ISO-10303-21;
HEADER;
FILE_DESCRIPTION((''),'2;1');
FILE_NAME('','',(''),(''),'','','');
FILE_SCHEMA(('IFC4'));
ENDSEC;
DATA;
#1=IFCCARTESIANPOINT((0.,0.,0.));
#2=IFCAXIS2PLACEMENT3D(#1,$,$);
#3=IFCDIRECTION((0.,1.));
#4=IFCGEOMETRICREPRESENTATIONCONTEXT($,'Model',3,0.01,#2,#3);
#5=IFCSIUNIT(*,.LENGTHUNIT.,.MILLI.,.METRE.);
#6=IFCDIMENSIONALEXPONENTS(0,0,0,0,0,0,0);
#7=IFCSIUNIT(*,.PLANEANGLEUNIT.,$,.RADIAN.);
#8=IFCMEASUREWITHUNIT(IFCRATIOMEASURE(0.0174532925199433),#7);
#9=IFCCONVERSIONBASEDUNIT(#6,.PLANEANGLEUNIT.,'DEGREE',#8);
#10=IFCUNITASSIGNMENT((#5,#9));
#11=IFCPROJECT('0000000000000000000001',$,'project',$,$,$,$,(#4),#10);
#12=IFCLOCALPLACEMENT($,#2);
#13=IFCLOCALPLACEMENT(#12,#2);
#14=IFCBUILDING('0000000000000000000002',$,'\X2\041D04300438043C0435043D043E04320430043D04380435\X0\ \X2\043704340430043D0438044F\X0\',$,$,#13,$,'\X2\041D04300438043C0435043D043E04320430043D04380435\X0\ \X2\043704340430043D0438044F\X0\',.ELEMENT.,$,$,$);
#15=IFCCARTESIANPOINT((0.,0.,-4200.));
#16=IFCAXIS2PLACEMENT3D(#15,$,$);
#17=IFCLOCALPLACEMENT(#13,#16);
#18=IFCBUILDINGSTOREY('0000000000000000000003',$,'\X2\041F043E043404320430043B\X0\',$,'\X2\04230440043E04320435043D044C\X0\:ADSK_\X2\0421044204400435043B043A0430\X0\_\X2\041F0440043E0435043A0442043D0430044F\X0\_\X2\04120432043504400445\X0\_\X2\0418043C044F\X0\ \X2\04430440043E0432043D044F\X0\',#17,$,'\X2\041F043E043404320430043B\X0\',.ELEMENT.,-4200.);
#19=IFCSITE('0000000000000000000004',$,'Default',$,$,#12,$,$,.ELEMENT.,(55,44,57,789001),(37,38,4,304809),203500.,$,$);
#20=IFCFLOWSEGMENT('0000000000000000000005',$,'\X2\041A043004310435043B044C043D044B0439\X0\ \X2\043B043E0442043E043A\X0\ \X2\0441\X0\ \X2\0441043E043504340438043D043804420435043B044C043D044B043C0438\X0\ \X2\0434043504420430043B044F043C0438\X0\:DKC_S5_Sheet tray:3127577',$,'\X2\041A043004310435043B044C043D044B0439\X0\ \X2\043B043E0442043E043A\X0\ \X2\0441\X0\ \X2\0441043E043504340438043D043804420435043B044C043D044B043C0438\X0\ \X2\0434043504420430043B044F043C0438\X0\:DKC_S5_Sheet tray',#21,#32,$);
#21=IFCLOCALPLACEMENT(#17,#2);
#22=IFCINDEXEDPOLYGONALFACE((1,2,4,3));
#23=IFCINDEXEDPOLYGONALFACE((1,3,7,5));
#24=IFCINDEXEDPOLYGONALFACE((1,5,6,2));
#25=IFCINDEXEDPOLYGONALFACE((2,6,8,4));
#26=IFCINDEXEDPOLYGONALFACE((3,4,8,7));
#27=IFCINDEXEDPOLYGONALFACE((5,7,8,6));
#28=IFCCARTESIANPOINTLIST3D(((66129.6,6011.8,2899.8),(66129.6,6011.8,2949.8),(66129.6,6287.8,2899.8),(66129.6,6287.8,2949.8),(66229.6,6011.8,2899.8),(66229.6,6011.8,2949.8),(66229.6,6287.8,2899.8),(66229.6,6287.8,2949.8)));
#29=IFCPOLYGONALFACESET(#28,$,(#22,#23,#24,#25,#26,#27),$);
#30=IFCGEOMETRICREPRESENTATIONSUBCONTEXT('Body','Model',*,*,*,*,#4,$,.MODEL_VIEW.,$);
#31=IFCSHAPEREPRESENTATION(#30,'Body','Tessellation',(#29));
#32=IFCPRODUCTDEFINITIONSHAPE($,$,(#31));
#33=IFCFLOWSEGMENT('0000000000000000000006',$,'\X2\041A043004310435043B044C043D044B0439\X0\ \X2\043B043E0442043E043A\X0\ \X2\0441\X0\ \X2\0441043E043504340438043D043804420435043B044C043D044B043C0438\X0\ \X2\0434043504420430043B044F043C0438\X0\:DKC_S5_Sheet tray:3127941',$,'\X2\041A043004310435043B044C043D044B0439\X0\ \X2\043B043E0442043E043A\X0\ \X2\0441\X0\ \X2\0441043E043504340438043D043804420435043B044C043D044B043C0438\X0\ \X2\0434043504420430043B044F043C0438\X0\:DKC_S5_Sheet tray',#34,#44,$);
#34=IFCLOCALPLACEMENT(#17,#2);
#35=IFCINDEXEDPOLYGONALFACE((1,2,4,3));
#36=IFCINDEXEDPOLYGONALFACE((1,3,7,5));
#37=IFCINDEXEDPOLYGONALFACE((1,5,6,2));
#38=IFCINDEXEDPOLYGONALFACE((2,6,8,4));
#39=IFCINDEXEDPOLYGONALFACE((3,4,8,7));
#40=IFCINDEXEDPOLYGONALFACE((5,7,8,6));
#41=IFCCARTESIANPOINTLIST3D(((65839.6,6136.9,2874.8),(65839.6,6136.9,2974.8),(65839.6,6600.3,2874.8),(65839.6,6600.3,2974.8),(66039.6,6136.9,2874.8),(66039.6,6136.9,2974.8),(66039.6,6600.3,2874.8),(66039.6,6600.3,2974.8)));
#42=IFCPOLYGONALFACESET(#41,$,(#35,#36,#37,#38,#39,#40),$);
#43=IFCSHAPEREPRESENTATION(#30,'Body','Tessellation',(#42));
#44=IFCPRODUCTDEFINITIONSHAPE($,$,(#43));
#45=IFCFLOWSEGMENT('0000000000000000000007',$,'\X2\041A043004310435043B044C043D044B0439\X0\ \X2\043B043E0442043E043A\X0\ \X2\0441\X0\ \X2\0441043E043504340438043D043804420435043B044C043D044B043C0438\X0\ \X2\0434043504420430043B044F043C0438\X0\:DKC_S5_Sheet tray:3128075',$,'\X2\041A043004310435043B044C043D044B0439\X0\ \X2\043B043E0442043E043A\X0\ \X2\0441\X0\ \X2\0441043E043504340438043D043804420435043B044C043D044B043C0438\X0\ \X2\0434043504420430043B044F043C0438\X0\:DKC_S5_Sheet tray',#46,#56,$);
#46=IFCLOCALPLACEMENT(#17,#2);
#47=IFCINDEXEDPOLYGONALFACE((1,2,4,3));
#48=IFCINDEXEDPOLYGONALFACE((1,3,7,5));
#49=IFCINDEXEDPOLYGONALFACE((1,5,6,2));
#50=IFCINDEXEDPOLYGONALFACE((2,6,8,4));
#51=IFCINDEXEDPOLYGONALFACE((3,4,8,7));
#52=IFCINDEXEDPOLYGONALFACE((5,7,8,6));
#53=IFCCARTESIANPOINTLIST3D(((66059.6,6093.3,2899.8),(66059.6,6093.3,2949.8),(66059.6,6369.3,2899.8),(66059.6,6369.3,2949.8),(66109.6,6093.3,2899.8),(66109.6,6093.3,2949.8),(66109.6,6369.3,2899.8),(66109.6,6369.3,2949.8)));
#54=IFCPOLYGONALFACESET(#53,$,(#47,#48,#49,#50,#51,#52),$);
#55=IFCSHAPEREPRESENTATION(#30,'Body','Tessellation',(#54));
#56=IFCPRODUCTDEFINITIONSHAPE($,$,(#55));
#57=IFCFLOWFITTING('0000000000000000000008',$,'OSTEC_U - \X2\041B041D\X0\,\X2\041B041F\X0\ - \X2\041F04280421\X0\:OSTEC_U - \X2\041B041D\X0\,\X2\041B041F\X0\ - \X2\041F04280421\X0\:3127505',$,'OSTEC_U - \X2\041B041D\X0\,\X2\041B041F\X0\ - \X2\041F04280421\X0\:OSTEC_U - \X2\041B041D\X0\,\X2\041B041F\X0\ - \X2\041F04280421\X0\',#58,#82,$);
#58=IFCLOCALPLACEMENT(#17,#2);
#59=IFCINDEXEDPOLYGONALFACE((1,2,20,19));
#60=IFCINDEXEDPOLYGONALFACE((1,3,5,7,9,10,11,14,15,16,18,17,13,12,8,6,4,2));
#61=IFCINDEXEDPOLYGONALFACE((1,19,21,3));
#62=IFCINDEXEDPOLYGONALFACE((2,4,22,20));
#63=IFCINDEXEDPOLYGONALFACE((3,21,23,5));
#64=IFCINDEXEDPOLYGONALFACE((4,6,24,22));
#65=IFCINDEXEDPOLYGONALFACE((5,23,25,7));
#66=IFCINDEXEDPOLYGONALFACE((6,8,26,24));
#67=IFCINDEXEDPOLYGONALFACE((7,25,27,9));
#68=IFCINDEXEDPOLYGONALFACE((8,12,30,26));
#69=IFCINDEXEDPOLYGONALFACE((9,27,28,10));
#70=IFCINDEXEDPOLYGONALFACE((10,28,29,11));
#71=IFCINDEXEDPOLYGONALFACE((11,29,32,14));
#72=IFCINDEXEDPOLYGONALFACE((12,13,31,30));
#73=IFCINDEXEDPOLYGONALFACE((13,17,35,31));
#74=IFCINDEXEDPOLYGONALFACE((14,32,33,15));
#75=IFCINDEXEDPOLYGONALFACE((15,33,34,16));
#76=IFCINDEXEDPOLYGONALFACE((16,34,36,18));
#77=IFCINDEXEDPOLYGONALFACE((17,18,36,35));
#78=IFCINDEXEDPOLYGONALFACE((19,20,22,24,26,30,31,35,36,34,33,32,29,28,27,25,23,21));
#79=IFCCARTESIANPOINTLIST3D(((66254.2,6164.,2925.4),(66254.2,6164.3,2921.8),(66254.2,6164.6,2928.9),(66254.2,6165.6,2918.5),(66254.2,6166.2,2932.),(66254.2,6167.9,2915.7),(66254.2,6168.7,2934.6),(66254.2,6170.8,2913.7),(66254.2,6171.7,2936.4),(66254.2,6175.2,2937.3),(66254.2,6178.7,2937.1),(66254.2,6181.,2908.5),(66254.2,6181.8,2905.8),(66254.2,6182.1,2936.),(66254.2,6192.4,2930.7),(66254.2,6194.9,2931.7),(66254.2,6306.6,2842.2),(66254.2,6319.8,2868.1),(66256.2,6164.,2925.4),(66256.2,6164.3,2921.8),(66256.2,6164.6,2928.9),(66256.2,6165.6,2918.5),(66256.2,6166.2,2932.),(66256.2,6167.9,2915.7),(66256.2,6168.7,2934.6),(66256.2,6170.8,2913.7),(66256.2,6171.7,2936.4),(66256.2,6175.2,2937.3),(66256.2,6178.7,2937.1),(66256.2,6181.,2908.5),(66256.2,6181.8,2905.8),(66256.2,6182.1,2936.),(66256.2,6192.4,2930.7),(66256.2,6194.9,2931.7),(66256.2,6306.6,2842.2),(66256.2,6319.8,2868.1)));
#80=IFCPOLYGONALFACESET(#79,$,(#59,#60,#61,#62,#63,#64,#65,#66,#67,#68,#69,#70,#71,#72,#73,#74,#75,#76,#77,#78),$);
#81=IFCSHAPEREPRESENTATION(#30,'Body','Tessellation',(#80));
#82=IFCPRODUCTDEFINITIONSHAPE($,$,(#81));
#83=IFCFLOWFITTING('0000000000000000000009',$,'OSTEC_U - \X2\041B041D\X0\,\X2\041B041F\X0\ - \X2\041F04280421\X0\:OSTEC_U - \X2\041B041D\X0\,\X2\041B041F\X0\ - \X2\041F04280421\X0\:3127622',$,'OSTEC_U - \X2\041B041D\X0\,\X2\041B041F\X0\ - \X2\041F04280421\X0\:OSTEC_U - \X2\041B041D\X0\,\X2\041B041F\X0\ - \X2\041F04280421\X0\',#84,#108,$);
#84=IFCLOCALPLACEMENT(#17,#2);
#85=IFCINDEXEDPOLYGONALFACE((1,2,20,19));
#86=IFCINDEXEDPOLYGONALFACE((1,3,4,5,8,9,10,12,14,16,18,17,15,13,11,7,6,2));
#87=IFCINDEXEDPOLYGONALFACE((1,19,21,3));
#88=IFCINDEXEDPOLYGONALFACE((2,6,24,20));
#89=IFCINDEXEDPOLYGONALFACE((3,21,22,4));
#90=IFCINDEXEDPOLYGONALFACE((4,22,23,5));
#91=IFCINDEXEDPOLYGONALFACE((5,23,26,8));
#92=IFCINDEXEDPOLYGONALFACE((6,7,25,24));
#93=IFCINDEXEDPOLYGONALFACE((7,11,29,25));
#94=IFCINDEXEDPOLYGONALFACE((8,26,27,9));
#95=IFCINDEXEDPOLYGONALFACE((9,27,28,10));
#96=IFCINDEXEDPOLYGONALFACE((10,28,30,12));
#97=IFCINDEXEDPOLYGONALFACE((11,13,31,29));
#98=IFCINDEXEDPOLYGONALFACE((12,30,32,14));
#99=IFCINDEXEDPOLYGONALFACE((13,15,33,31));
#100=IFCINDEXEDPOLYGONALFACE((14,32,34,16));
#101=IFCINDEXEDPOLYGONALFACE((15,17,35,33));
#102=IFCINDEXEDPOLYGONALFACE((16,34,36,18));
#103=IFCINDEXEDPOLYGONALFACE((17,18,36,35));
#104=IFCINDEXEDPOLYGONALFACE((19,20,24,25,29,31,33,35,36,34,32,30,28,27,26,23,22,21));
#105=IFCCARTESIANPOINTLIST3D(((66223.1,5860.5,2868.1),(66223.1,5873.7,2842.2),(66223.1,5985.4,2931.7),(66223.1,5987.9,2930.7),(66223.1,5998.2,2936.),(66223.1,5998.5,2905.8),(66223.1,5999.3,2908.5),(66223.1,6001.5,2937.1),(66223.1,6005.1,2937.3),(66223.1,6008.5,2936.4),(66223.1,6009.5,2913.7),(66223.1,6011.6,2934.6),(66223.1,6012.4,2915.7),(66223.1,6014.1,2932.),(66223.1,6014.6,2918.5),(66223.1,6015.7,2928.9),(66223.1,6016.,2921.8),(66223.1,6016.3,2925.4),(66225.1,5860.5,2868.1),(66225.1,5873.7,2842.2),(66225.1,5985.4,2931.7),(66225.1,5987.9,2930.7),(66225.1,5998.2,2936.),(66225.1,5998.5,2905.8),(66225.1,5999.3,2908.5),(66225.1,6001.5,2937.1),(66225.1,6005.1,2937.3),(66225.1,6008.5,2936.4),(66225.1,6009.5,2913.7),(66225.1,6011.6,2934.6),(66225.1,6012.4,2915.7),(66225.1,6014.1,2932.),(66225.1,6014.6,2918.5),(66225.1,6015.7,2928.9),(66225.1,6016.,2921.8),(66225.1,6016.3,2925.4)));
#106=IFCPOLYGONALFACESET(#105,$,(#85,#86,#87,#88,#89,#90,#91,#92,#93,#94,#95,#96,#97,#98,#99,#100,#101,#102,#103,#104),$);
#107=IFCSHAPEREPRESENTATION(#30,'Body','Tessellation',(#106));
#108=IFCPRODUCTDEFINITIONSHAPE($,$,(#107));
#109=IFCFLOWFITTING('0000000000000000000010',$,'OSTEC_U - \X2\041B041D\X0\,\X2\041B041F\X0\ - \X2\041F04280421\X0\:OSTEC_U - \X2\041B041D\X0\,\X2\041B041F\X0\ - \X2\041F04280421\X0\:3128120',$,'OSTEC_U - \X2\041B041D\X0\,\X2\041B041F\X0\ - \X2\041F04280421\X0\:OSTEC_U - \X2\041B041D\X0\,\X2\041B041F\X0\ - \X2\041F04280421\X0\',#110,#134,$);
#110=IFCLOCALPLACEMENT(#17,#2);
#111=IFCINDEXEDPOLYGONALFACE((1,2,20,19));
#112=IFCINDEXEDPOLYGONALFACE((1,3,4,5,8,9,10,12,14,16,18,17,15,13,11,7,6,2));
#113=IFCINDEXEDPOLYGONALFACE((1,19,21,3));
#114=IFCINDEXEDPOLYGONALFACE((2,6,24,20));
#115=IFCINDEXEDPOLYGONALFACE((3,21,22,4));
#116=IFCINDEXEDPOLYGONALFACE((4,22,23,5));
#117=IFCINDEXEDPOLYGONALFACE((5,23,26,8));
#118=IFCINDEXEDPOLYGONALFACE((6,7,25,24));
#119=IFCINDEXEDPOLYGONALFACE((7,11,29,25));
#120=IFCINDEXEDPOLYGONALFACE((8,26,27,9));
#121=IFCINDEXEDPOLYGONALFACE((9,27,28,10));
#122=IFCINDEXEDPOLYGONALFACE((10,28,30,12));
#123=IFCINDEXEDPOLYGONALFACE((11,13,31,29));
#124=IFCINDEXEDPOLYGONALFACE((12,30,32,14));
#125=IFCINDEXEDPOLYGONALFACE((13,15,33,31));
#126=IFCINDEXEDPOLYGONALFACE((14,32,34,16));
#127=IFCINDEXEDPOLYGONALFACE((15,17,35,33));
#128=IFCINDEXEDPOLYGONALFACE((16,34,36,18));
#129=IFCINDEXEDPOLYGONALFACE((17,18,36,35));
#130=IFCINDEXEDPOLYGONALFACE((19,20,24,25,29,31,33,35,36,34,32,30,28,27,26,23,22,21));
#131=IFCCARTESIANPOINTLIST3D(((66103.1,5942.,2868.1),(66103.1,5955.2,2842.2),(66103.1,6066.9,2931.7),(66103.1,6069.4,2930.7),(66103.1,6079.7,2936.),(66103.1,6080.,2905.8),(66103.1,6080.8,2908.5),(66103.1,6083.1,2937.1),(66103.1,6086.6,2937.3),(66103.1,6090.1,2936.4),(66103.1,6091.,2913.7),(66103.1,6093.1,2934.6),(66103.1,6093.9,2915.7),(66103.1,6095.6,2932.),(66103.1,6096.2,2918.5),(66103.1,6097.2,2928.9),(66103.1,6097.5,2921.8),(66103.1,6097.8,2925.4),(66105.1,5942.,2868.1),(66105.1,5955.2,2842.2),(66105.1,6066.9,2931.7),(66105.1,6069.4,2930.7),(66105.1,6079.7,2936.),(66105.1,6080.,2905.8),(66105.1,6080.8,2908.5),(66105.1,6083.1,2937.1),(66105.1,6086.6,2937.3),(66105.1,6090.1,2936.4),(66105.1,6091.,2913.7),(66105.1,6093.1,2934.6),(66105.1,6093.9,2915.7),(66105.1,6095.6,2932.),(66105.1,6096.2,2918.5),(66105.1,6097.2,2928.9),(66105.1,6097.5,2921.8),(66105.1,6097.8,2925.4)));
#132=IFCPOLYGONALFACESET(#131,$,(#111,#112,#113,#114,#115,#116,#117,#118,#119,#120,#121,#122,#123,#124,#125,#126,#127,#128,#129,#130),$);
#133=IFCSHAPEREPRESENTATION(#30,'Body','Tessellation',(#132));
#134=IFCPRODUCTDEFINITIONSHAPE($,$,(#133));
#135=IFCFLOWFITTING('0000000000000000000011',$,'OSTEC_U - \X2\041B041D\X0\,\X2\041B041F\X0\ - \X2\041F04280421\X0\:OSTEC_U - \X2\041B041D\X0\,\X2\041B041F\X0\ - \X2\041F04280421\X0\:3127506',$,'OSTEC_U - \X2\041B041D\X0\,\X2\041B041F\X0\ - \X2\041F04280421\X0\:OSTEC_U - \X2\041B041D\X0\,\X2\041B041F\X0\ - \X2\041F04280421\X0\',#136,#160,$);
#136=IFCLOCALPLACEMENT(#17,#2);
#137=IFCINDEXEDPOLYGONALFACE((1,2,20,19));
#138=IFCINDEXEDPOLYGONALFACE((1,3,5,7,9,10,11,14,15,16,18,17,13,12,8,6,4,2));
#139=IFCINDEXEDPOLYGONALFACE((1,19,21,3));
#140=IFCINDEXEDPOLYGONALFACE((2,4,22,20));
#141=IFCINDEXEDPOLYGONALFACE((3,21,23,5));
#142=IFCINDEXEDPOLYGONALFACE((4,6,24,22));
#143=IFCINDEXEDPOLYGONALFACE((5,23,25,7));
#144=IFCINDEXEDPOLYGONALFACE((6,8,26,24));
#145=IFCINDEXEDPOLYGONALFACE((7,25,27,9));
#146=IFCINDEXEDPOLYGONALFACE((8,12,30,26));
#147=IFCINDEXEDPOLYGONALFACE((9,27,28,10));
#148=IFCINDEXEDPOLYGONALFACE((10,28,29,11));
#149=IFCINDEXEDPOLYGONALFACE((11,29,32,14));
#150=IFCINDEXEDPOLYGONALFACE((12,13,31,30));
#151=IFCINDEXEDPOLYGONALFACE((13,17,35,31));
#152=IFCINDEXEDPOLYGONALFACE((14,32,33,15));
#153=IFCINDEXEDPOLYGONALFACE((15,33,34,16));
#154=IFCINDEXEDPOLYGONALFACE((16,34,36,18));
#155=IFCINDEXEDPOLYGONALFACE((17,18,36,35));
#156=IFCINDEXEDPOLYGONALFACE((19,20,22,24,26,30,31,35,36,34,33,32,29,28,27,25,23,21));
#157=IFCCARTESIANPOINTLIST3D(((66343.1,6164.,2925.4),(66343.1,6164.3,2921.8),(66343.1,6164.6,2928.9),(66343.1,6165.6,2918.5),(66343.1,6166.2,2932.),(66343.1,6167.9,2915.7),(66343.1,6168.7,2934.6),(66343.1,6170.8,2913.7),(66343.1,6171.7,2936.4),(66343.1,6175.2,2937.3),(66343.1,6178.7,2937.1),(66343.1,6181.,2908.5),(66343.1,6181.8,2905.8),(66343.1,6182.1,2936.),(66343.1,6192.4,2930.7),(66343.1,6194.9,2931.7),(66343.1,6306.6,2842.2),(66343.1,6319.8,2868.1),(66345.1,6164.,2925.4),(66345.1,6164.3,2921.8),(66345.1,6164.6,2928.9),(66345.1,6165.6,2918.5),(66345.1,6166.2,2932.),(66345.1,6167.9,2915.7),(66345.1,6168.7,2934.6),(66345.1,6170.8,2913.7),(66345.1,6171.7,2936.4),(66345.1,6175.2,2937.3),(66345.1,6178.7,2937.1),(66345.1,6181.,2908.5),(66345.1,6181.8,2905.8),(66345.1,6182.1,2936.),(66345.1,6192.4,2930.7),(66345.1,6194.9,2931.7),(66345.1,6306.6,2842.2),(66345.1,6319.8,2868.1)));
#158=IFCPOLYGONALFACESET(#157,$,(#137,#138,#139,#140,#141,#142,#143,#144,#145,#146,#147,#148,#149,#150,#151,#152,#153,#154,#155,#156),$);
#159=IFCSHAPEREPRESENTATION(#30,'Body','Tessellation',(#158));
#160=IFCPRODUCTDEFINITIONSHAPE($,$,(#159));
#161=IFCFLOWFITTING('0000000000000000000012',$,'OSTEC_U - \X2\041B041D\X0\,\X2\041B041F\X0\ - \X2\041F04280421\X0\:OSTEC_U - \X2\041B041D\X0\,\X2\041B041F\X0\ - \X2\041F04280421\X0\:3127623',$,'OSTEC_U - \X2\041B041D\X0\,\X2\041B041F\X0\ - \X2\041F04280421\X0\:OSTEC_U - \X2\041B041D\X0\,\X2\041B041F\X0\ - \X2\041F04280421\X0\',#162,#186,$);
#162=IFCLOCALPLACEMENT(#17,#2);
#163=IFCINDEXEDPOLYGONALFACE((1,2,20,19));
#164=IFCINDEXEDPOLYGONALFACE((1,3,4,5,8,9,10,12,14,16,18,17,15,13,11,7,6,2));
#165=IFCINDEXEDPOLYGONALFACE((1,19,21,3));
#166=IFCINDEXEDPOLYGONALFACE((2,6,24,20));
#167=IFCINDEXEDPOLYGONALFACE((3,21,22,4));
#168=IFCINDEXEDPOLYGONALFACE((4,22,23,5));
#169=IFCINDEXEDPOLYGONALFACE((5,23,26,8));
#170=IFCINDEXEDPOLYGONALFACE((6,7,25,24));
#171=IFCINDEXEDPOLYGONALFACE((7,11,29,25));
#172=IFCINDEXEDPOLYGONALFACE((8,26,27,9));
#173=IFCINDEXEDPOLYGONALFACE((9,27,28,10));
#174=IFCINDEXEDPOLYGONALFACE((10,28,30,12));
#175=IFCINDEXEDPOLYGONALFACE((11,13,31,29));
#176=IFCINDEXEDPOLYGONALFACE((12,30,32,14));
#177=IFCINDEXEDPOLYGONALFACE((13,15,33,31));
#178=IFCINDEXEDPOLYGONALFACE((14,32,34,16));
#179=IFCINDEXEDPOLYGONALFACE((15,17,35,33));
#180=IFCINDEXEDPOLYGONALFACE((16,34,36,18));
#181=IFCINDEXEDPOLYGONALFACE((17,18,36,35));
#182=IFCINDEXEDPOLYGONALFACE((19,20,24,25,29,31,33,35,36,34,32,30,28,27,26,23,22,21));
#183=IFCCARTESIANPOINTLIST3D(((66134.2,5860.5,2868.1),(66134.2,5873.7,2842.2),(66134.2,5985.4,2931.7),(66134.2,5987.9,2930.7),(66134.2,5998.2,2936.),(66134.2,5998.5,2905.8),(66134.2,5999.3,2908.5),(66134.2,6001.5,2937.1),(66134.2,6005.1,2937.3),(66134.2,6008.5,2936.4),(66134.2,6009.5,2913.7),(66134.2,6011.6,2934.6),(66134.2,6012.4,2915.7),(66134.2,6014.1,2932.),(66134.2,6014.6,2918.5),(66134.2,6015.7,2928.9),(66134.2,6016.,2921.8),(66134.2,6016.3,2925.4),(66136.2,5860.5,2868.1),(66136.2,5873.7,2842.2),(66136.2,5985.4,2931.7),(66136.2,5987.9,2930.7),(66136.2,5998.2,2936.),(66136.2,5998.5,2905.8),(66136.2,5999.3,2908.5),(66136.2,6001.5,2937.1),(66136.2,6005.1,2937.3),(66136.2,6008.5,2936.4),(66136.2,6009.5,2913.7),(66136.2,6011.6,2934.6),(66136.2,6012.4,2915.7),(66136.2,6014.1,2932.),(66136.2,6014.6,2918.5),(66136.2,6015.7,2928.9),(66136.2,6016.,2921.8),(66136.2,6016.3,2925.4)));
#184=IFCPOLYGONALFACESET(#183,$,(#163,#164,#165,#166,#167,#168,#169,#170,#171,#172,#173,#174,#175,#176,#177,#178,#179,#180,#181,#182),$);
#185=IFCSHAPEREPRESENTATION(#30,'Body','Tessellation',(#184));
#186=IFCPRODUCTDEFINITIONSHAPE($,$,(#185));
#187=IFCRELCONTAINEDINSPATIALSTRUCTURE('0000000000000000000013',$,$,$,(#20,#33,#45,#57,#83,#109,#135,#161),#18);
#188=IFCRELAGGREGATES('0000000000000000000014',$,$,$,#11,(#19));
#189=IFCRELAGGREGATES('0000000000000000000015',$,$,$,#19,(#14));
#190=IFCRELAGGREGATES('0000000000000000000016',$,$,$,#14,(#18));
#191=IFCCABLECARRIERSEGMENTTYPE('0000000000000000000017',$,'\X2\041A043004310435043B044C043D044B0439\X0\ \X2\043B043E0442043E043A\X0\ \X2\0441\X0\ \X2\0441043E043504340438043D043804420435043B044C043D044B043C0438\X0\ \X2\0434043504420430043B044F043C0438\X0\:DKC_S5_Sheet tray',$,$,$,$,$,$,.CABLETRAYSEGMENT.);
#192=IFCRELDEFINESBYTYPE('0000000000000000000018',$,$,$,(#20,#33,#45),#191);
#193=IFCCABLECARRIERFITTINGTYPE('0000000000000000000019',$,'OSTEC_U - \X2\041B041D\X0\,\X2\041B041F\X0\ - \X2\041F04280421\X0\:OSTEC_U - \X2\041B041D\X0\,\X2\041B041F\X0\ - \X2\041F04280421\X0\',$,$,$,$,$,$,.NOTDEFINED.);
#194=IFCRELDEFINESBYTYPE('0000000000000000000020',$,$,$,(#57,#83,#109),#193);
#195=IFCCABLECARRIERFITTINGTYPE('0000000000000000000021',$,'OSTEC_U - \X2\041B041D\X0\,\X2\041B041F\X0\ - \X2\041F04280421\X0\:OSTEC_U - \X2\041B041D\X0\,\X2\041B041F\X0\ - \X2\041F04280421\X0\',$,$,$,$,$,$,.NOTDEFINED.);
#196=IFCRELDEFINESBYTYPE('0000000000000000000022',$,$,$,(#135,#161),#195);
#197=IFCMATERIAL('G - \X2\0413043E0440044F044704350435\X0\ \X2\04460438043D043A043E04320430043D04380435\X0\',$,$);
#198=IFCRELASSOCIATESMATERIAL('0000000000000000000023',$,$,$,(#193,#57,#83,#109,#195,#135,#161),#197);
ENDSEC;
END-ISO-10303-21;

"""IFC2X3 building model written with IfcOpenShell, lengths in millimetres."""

from ifc_helpers import new_model, entity, si_unit, converted_unit, direction, frame, frame_2d, origin, origin_2d_with_axis, place, context, subcontext, project, spatial, polyline, circle_curve, parameter, trimmed, segment, composite_curve, rectangle, outline, extrude, source, transform, mapped, material, type_object, type_shapes, element, save


model = new_model("IFC2X3")

# Units and contexts
model_context = context("Model", 3, precision=0.01, world=origin(), true_north=direction((0.0, 1.0)))
body_context = subcontext(model_context, "Body", "Model", "MODEL_VIEW")
ifc_project = project(units=[si_unit("LENGTHUNIT", "METRE", prefix="MILLI"), converted_unit("PLANEANGLEUNIT", "DEGREE", entity("IfcRatioMeasure", 0.0174532925199433), si_unit("PLANEANGLEUNIT", "RADIAN"), dimensions=[0, 0, 0, 0, 0, 0, 0])], contexts=[model_context])

# Site, building, storey
site_placement = place(None, origin())
site = spatial("IfcSite", under=ifc_project, at=site_placement, Name="Default", CompositionType="ELEMENT", RefLatitude=(55, 44, 57, 789001), RefLongitude=(37, 38, 4, 304809), RefElevation=203500.0)
building_placement = place(site_placement, origin())
building = spatial("IfcBuilding", under=site, at=building_placement, Name="Наименование здания", LongName="Наименование здания", CompositionType="ELEMENT")
storey_placement = place(building_placement, frame((0.0, 0.0, -4200.0)))
storey = spatial("IfcBuildingStorey", under=building, at=storey_placement, Name="Подвал", ObjectType="Уровень:ADSK_Стрелка_Проектная_Вверх_Имя уровня", LongName="Подвал", CompositionType="ELEMENT", Elevation=-4200.0)

# Flow segments
cable_carrier_segment_type = type_object("IfcCableCarrierSegmentType", Name="Кабельный лоток с соединительными деталями:DKC_S5_Sheet tray", PredefinedType="CABLETRAYSEGMENT")
flow_segment_1_placement = place(storey_placement, frame((66129.6, 6011.8, 2899.8)))
element("IfcFlowSegment", 1, at=flow_segment_1_placement, inside=storey, type_object=cable_carrier_segment_type, Name="Кабельный лоток с соединительными деталями:DKC_S5_Sheet tray:3127577", ObjectType="Кабельный лоток с соединительными деталями:DKC_S5_Sheet tray", context=body_context, shape_type="SweptSolid", body=[
    extrude(rectangle(XDim=276.0, YDim=100.0, at=origin_2d_with_axis()), frame((50.0, 138.0, 0.0), z_axis=(0.0, 0.0, 1.0), x_axis=(0.0, -1.0, 0.0)), (0.0, 0.0, 1.0), 50.0),
])
flow_segment_2_placement = place(storey_placement, frame((65839.6, 6136.9, 2874.8)))
element("IfcFlowSegment", 2, at=flow_segment_2_placement, inside=storey, type_object=cable_carrier_segment_type, Name="Кабельный лоток с соединительными деталями:DKC_S5_Sheet tray:3127941", ObjectType="Кабельный лоток с соединительными деталями:DKC_S5_Sheet tray", context=body_context, shape_type="SweptSolid", body=[
    extrude(rectangle(XDim=463.4, YDim=200.0, at=origin_2d_with_axis()), frame((100.0, 231.7, 0.0), z_axis=(0.0, 0.0, 1.0), x_axis=(0.0, -1.0, 0.0)), (0.0, 0.0, 1.0), 100.0),
])
flow_segment_3_placement = place(storey_placement, frame((66059.6, 6093.3, 2899.8)))
element("IfcFlowSegment", 3, at=flow_segment_3_placement, inside=storey, type_object=cable_carrier_segment_type, Name="Кабельный лоток с соединительными деталями:DKC_S5_Sheet tray:3128075", ObjectType="Кабельный лоток с соединительными деталями:DKC_S5_Sheet tray", context=body_context, shape_type="SweptSolid", body=[
    extrude(rectangle(XDim=276.0, YDim=50.0, at=origin_2d_with_axis()), frame((25.0, 138.0, 0.0), z_axis=(0.0, 0.0, 1.0), x_axis=(0.0, -1.0, 0.0)), (0.0, 0.0, 1.0), 50.0),
])

# Flow fittings
ifc_material = material(Name="G - Горячее цинкование")
cable_carrier_fitting_type_1 = type_object("IfcCableCarrierFittingType", Name="OSTEC_U - ЛН,ЛП - ПШС:OSTEC_U - ЛН,ЛП - ПШС", PredefinedType="NOTDEFINED", material=ifc_material)
shared_shape_1 = source(origin(), body_context, "Body", "SweptSolid", [
    extrude(outline(composite_curve([segment(trimmed(circle_curve(frame_2d((-44.6, 0.0), x_axis=(1.0, 0.0)), 12.5), [parameter(90.0)], [parameter(270.0)], True, "PARAMETER"), True, "CONTINUOUS"), segment(polyline([(-44.6, -12.5), (-33.1, -12.5)]), True, "CONTINUOUS"), segment(polyline([(-33.1, -12.5), (-31.2, -14.5)]), True, "CONTINUOUS"), segment(polyline([(-31.2, -14.5), (108.9, -14.5)]), True, "CONTINUOUS"), segment(polyline([(108.9, -14.5), (108.9, 14.5)]), True, "CONTINUOUS"), segment(polyline([(108.9, 14.5), (-31.2, 14.5)]), True, "CONTINUOUS"), segment(polyline([(-31.2, 14.5), (-33.1, 12.5)]), True, "CONTINUOUS"), segment(polyline([(-33.1, 12.5), (-44.6, 12.5)]), True, "CONTINUOUS")], self_intersect=False)), frame((44.6, 0.0, 0.0), z_axis=(0.0, 0.0, -1.0), x_axis=(1.0, 0.0, 0.0)), (0.0, 0.0, -1.0), 2.0),
])
type_shapes(cable_carrier_fitting_type_1, [shared_shape_1])
flow_fitting_1_placement = place(storey_placement, frame((66256.2, 6176.4, 2924.8), z_axis=(-1.0, 0.0, 0.0), x_axis=(0.0, 0.891007, -0.45399)))
element("IfcFlowFitting", 4, at=flow_fitting_1_placement, inside=storey, type_object=cable_carrier_fitting_type_1, material=ifc_material, Name="OSTEC_U - ЛН,ЛП - ПШС:OSTEC_U - ЛН,ЛП - ПШС:3127505", ObjectType="OSTEC_U - ЛН,ЛП - ПШС:OSTEC_U - ЛН,ЛП - ПШС", context=body_context, shape_type="MappedRepresentation", body=[
    mapped(shared_shape_1, transform((0.0, 0.0, 0.0), scale=1.0)),
])
flow_fitting_2_placement = place(storey_placement, frame((66223.1, 6003.8, 2924.8), z_axis=(1.0, 0.0, 0.0), x_axis=(0.0, -0.891007, -0.45399)))
element("IfcFlowFitting", 5, at=flow_fitting_2_placement, inside=storey, type_object=cable_carrier_fitting_type_1, material=ifc_material, Name="OSTEC_U - ЛН,ЛП - ПШС:OSTEC_U - ЛН,ЛП - ПШС:3127622", ObjectType="OSTEC_U - ЛН,ЛП - ПШС:OSTEC_U - ЛН,ЛП - ПШС", context=body_context, shape_type="MappedRepresentation", body=[
    mapped(shared_shape_1, transform((0.0, 0.0, 0.0), scale=1.0)),
])
flow_fitting_3_placement = place(storey_placement, frame((66103.1, 6085.4, 2924.8), z_axis=(1.0, 0.0, 0.0), x_axis=(0.0, -0.891007, -0.45399)))
element("IfcFlowFitting", 6, at=flow_fitting_3_placement, inside=storey, type_object=cable_carrier_fitting_type_1, material=ifc_material, Name="OSTEC_U - ЛН,ЛП - ПШС:OSTEC_U - ЛН,ЛП - ПШС:3128120", ObjectType="OSTEC_U - ЛН,ЛП - ПШС:OSTEC_U - ЛН,ЛП - ПШС", context=body_context, shape_type="MappedRepresentation", body=[
    mapped(shared_shape_1, transform((0.0, 0.0, 0.0), scale=1.0)),
])
shared_shape_2 = source(origin(), body_context, "Body", "SweptSolid", [
    extrude(outline(composite_curve([segment(trimmed(circle_curve(frame_2d((-44.6, 0.0), x_axis=(1.0, 0.0)), 12.5), [parameter(90.0)], [parameter(270.0)], True, "PARAMETER"), True, "CONTINUOUS"), segment(polyline([(-44.6, -12.5), (-33.1, -12.5)]), True, "CONTINUOUS"), segment(polyline([(-33.1, -12.5), (-31.2, -14.5)]), True, "CONTINUOUS"), segment(polyline([(-31.2, -14.5), (108.9, -14.5)]), True, "CONTINUOUS"), segment(polyline([(108.9, -14.5), (108.9, 14.5)]), True, "CONTINUOUS"), segment(polyline([(108.9, 14.5), (-31.2, 14.5)]), True, "CONTINUOUS"), segment(polyline([(-31.2, 14.5), (-33.1, 12.5)]), True, "CONTINUOUS"), segment(polyline([(-33.1, 12.5), (-44.6, 12.5)]), True, "CONTINUOUS")], self_intersect=False)), frame((44.6, 0.0, 0.0)), (0.0, 0.0, 1.0), 2.0),
])
cable_carrier_fitting_type_2 = type_object("IfcCableCarrierFittingType", Name="OSTEC_U - ЛН,ЛП - ПШС:OSTEC_U - ЛН,ЛП - ПШС", PredefinedType="NOTDEFINED", material=ifc_material)
type_shapes(cable_carrier_fitting_type_2, [shared_shape_2])
flow_fitting_4_placement = place(storey_placement, frame((66343.1, 6176.4, 2924.8), z_axis=(1.0, 0.0, 0.0), x_axis=(0.0, 0.891007, -0.45399)))
element("IfcFlowFitting", 7, at=flow_fitting_4_placement, inside=storey, type_object=cable_carrier_fitting_type_2, material=ifc_material, Name="OSTEC_U - ЛН,ЛП - ПШС:OSTEC_U - ЛН,ЛП - ПШС:3127506", ObjectType="OSTEC_U - ЛН,ЛП - ПШС:OSTEC_U - ЛН,ЛП - ПШС", context=body_context, shape_type="MappedRepresentation", body=[
    mapped(shared_shape_2, transform((0.0, 0.0, 0.0), scale=1.0)),
])
flow_fitting_5_placement = place(storey_placement, frame((66136.2, 6003.8, 2924.8), z_axis=(-1.0, 0.0, 0.0), x_axis=(0.0, -0.891007, -0.45399)))
element("IfcFlowFitting", 8, at=flow_fitting_5_placement, inside=storey, type_object=cable_carrier_fitting_type_2, material=ifc_material, Name="OSTEC_U - ЛН,ЛП - ПШС:OSTEC_U - ЛН,ЛП - ПШС:3127623", ObjectType="OSTEC_U - ЛН,ЛП - ПШС:OSTEC_U - ЛН,ЛП - ПШС", context=body_context, shape_type="MappedRepresentation", body=[
    mapped(shared_shape_2, transform((0.0, 0.0, 0.0), scale=1.0)),
])

save(model, "model.ifc")
